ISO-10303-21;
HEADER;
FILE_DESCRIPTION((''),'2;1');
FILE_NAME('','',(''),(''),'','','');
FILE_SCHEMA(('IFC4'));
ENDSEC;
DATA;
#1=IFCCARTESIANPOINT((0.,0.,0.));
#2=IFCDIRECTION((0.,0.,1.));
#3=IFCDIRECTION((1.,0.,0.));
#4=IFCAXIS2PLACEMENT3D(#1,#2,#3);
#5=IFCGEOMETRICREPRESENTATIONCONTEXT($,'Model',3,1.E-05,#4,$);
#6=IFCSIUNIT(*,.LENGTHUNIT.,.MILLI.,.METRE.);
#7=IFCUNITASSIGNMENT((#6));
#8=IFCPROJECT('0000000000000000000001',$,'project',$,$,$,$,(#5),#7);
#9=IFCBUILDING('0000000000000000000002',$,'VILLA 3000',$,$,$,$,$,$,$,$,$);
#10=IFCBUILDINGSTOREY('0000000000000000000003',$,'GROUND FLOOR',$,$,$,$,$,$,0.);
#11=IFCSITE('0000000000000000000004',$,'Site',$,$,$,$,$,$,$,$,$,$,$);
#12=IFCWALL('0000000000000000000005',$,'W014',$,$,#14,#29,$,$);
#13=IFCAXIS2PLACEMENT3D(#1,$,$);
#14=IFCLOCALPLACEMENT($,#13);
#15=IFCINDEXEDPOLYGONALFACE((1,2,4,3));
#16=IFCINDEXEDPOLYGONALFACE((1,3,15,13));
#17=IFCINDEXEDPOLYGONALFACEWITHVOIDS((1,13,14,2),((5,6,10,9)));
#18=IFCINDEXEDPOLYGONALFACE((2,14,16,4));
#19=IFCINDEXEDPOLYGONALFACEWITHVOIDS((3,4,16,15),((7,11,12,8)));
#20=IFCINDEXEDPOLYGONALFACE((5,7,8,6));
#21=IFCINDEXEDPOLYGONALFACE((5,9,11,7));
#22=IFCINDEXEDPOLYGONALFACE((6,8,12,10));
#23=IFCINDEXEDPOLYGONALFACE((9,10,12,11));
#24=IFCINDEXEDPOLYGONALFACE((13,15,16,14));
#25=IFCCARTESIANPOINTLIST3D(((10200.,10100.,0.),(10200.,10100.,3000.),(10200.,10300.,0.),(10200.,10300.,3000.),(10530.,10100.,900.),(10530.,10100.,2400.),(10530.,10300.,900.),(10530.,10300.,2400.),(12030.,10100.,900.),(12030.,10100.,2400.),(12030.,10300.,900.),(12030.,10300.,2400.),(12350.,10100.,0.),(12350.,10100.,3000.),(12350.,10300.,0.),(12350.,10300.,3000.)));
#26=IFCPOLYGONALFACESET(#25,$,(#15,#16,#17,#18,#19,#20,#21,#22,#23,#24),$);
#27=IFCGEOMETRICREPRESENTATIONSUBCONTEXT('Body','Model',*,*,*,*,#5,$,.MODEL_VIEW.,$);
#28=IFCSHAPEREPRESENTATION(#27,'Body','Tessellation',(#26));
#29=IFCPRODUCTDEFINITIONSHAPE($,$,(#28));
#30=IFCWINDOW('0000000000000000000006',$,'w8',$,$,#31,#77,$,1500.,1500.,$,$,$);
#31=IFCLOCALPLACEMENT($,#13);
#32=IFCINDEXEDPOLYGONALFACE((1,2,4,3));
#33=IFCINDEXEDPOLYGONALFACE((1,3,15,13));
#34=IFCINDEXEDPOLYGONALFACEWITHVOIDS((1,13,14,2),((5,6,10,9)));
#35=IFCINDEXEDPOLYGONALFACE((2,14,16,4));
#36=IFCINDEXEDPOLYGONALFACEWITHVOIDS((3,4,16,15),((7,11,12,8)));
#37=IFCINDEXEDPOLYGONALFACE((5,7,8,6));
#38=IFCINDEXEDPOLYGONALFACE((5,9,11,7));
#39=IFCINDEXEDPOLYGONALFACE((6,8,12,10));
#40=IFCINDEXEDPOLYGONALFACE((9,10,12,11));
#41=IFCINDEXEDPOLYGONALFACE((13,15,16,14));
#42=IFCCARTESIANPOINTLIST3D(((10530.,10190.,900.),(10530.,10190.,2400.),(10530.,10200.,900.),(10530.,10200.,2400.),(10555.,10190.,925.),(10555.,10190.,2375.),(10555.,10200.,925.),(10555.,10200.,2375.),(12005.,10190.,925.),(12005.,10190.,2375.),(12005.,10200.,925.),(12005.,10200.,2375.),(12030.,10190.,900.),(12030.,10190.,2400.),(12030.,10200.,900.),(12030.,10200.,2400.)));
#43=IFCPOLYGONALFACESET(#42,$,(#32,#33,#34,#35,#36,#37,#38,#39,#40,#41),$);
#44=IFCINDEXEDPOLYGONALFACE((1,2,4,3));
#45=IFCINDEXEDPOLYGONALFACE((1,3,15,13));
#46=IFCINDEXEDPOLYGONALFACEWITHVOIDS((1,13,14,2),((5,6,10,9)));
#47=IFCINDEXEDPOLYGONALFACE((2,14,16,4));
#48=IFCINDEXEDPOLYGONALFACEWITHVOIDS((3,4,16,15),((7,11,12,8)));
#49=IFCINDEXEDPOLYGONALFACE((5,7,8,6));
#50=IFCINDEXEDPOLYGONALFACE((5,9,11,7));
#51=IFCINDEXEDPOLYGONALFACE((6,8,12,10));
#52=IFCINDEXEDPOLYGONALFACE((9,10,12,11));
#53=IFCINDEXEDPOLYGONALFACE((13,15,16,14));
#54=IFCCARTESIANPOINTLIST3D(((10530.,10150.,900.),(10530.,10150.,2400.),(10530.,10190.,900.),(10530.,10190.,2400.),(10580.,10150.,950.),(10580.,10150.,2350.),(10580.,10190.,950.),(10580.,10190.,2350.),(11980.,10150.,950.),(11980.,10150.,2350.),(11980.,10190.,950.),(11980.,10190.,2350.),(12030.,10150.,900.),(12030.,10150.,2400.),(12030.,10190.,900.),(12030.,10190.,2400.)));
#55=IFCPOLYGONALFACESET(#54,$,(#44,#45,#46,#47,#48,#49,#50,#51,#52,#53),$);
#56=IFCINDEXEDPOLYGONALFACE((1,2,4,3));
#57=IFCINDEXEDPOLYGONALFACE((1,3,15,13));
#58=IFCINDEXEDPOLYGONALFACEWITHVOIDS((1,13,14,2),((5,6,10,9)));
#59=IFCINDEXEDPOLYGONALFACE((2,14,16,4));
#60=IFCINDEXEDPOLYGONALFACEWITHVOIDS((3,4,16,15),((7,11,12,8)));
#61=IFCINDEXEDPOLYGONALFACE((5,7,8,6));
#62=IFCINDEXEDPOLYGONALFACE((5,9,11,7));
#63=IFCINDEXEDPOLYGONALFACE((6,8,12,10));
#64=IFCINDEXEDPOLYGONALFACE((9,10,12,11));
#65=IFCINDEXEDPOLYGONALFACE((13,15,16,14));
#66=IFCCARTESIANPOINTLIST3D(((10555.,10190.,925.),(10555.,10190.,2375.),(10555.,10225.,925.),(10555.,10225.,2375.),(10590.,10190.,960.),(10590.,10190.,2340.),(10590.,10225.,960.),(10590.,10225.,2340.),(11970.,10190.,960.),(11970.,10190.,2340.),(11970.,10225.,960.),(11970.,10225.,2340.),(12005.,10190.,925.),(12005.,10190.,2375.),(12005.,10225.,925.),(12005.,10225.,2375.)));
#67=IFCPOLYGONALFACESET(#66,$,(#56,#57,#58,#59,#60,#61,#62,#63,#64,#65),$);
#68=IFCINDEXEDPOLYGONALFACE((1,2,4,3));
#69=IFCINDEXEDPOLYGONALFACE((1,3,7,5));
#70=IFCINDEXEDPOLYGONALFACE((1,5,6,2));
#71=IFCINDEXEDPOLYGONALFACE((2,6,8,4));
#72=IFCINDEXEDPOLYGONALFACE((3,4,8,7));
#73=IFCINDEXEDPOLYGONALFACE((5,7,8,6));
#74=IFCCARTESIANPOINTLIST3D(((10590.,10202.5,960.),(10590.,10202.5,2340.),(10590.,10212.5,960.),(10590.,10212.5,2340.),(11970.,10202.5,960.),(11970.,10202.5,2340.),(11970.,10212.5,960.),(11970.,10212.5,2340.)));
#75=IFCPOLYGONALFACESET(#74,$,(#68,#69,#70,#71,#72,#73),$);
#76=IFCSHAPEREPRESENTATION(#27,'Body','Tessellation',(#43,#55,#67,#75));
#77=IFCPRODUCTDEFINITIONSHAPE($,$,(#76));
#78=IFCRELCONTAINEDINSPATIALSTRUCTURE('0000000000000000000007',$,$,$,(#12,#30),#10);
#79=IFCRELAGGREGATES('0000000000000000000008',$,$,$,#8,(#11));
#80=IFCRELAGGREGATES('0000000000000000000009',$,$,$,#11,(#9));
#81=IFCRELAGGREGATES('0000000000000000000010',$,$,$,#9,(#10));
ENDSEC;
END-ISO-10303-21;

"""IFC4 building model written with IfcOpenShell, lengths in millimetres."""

from ifc_helpers import new_model, si_unit, frame, origin_with_axes, place, context, subcontext, project, spatial, line, indexed_curve, outline, extrude, element, fill, save


model = new_model("IFC4")

# Units and contexts
model_context = context("Model", 3, precision=1e-05, world=origin_with_axes())
body_context = subcontext(model_context, "Body", "Model", "MODEL_VIEW")
ifc_project = project(units=[si_unit("LENGTHUNIT", "METRE", prefix="MILLI")], contexts=[model_context])

# Site, building, storey
site = spatial("IfcSite", under=ifc_project, Name="Site")
building = spatial("IfcBuilding", under=site, Name="VILLA 3000")
storey = spatial("IfcBuildingStorey", under=building, Name="GROUND FLOOR", Elevation=0.0)

# Wall, opening, window
wall_1_placement = place(None, frame((10200.0, 10200.0, 0.0), z_axis=(0.0, 0.0, 1.0), x_axis=(1.0, 0.0, 0.0)))
wall_1 = element("IfcWall", 1, at=wall_1_placement, inside=storey, Name="W014", context=body_context, shape_type="SweptSolid", body=[
    extrude(outline(indexed_curve([(0.0, 0.0), (0.0, 200.0), (2150.0, 200.0), (2150.0, 0.0), (0.0, 0.0)], self_intersect=False)), frame((0.0, -100.0, 0.0), z_axis=(0.0, 0.0, 1.0), x_axis=(1.0, 0.0, 0.0)), (0.0, 0.0, 1.0), 3000.0),
])
opening_1_placement = place(wall_1_placement, frame((330.0, 0.0, 900.0), z_axis=(0.0, 0.0, 1.0), x_axis=(1.0, 0.0, 0.0)))
opening_1 = element("IfcOpeningElement", 2, at=opening_1_placement, cuts=wall_1, context=body_context, shape_type="SweptSolid", body=[
    extrude(outline(indexed_curve([(0.0, 0.0), (0.0, 300.0), (1500.0, 300.0), (1500.0, 0.0), (0.0, 0.0)], self_intersect=False)), frame((0.0, -150.0, 0.0), z_axis=(0.0, 0.0, 1.0), x_axis=(1.0, 0.0, 0.0)), (0.0, 0.0, 1.0), 1500.0),
])
window_1_placement = place(None, frame((10530.0, 10100.0, 900.0), z_axis=(0.0, 0.0, 1.0), x_axis=(1.0, 0.0, 0.0)))
window_1 = element("IfcWindow", 3, at=window_1_placement, inside=storey, Name="w8", OverallHeight=1500.0, OverallWidth=1500.0, context=body_context, shape_type="SweptSolid", body=[
    extrude(outline(indexed_curve([(0.0, 0.0), (1500.0, 0.0), (1500.0, 1500.0), (0.0, 1500.0)], segments=[line(1, 2, 3, 4, 1)]), holes=[indexed_curve([(25.0, 25.0), (1475.0, 25.0), (1475.0, 1475.0), (25.0, 1475.0)], segments=[line(1, 2, 3, 4, 1)])]), frame((0.0, 90.0, 0.0), z_axis=(0.0, -1.0, 0.0), x_axis=(1.0, 0.0, 0.0)), (0.0, 0.0, -1.0), 10.0),
    extrude(outline(indexed_curve([(0.0, 0.0), (1500.0, 0.0), (1500.0, 1500.0), (0.0, 1500.0)], segments=[line(1, 2, 3, 4, 1)]), holes=[indexed_curve([(50.0, 50.0), (1450.0, 50.0), (1450.0, 1450.0), (50.0, 1450.0)], segments=[line(1, 2, 3, 4, 1)])]), frame((0.0, 50.0, 0.0), z_axis=(0.0, -1.0, 0.0), x_axis=(1.0, 0.0, 0.0)), (0.0, 0.0, -1.0), 40.0),
    extrude(outline(indexed_curve([(0.0, 0.0), (1450.0, 0.0), (1450.0, 1450.0), (0.0, 1450.0)], segments=[line(1, 2, 3, 4, 1)]), holes=[indexed_curve([(35.0, 35.0), (1415.0, 35.0), (1415.0, 1415.0), (35.0, 1415.0)], segments=[line(1, 2, 3, 4, 1)])]), frame((25.0, 90.0, 25.0), z_axis=(0.0, -1.0, 0.0), x_axis=(1.0, 0.0, 0.0)), (0.0, 0.0, -1.0), 35.0),
    extrude(outline(indexed_curve([(35.0, 35.0), (1415.0, 35.0), (1415.0, 1415.0), (35.0, 1415.0)], segments=[line(1, 2, 3, 4, 1)])), frame((25.0, 102.5, 25.0), z_axis=(0.0, -1.0, 0.0), x_axis=(1.0, 0.0, 0.0)), (0.0, 0.0, -1.0), 10.0),
])
fill(opening_1, window_1)

save(model, "model.ifc")
